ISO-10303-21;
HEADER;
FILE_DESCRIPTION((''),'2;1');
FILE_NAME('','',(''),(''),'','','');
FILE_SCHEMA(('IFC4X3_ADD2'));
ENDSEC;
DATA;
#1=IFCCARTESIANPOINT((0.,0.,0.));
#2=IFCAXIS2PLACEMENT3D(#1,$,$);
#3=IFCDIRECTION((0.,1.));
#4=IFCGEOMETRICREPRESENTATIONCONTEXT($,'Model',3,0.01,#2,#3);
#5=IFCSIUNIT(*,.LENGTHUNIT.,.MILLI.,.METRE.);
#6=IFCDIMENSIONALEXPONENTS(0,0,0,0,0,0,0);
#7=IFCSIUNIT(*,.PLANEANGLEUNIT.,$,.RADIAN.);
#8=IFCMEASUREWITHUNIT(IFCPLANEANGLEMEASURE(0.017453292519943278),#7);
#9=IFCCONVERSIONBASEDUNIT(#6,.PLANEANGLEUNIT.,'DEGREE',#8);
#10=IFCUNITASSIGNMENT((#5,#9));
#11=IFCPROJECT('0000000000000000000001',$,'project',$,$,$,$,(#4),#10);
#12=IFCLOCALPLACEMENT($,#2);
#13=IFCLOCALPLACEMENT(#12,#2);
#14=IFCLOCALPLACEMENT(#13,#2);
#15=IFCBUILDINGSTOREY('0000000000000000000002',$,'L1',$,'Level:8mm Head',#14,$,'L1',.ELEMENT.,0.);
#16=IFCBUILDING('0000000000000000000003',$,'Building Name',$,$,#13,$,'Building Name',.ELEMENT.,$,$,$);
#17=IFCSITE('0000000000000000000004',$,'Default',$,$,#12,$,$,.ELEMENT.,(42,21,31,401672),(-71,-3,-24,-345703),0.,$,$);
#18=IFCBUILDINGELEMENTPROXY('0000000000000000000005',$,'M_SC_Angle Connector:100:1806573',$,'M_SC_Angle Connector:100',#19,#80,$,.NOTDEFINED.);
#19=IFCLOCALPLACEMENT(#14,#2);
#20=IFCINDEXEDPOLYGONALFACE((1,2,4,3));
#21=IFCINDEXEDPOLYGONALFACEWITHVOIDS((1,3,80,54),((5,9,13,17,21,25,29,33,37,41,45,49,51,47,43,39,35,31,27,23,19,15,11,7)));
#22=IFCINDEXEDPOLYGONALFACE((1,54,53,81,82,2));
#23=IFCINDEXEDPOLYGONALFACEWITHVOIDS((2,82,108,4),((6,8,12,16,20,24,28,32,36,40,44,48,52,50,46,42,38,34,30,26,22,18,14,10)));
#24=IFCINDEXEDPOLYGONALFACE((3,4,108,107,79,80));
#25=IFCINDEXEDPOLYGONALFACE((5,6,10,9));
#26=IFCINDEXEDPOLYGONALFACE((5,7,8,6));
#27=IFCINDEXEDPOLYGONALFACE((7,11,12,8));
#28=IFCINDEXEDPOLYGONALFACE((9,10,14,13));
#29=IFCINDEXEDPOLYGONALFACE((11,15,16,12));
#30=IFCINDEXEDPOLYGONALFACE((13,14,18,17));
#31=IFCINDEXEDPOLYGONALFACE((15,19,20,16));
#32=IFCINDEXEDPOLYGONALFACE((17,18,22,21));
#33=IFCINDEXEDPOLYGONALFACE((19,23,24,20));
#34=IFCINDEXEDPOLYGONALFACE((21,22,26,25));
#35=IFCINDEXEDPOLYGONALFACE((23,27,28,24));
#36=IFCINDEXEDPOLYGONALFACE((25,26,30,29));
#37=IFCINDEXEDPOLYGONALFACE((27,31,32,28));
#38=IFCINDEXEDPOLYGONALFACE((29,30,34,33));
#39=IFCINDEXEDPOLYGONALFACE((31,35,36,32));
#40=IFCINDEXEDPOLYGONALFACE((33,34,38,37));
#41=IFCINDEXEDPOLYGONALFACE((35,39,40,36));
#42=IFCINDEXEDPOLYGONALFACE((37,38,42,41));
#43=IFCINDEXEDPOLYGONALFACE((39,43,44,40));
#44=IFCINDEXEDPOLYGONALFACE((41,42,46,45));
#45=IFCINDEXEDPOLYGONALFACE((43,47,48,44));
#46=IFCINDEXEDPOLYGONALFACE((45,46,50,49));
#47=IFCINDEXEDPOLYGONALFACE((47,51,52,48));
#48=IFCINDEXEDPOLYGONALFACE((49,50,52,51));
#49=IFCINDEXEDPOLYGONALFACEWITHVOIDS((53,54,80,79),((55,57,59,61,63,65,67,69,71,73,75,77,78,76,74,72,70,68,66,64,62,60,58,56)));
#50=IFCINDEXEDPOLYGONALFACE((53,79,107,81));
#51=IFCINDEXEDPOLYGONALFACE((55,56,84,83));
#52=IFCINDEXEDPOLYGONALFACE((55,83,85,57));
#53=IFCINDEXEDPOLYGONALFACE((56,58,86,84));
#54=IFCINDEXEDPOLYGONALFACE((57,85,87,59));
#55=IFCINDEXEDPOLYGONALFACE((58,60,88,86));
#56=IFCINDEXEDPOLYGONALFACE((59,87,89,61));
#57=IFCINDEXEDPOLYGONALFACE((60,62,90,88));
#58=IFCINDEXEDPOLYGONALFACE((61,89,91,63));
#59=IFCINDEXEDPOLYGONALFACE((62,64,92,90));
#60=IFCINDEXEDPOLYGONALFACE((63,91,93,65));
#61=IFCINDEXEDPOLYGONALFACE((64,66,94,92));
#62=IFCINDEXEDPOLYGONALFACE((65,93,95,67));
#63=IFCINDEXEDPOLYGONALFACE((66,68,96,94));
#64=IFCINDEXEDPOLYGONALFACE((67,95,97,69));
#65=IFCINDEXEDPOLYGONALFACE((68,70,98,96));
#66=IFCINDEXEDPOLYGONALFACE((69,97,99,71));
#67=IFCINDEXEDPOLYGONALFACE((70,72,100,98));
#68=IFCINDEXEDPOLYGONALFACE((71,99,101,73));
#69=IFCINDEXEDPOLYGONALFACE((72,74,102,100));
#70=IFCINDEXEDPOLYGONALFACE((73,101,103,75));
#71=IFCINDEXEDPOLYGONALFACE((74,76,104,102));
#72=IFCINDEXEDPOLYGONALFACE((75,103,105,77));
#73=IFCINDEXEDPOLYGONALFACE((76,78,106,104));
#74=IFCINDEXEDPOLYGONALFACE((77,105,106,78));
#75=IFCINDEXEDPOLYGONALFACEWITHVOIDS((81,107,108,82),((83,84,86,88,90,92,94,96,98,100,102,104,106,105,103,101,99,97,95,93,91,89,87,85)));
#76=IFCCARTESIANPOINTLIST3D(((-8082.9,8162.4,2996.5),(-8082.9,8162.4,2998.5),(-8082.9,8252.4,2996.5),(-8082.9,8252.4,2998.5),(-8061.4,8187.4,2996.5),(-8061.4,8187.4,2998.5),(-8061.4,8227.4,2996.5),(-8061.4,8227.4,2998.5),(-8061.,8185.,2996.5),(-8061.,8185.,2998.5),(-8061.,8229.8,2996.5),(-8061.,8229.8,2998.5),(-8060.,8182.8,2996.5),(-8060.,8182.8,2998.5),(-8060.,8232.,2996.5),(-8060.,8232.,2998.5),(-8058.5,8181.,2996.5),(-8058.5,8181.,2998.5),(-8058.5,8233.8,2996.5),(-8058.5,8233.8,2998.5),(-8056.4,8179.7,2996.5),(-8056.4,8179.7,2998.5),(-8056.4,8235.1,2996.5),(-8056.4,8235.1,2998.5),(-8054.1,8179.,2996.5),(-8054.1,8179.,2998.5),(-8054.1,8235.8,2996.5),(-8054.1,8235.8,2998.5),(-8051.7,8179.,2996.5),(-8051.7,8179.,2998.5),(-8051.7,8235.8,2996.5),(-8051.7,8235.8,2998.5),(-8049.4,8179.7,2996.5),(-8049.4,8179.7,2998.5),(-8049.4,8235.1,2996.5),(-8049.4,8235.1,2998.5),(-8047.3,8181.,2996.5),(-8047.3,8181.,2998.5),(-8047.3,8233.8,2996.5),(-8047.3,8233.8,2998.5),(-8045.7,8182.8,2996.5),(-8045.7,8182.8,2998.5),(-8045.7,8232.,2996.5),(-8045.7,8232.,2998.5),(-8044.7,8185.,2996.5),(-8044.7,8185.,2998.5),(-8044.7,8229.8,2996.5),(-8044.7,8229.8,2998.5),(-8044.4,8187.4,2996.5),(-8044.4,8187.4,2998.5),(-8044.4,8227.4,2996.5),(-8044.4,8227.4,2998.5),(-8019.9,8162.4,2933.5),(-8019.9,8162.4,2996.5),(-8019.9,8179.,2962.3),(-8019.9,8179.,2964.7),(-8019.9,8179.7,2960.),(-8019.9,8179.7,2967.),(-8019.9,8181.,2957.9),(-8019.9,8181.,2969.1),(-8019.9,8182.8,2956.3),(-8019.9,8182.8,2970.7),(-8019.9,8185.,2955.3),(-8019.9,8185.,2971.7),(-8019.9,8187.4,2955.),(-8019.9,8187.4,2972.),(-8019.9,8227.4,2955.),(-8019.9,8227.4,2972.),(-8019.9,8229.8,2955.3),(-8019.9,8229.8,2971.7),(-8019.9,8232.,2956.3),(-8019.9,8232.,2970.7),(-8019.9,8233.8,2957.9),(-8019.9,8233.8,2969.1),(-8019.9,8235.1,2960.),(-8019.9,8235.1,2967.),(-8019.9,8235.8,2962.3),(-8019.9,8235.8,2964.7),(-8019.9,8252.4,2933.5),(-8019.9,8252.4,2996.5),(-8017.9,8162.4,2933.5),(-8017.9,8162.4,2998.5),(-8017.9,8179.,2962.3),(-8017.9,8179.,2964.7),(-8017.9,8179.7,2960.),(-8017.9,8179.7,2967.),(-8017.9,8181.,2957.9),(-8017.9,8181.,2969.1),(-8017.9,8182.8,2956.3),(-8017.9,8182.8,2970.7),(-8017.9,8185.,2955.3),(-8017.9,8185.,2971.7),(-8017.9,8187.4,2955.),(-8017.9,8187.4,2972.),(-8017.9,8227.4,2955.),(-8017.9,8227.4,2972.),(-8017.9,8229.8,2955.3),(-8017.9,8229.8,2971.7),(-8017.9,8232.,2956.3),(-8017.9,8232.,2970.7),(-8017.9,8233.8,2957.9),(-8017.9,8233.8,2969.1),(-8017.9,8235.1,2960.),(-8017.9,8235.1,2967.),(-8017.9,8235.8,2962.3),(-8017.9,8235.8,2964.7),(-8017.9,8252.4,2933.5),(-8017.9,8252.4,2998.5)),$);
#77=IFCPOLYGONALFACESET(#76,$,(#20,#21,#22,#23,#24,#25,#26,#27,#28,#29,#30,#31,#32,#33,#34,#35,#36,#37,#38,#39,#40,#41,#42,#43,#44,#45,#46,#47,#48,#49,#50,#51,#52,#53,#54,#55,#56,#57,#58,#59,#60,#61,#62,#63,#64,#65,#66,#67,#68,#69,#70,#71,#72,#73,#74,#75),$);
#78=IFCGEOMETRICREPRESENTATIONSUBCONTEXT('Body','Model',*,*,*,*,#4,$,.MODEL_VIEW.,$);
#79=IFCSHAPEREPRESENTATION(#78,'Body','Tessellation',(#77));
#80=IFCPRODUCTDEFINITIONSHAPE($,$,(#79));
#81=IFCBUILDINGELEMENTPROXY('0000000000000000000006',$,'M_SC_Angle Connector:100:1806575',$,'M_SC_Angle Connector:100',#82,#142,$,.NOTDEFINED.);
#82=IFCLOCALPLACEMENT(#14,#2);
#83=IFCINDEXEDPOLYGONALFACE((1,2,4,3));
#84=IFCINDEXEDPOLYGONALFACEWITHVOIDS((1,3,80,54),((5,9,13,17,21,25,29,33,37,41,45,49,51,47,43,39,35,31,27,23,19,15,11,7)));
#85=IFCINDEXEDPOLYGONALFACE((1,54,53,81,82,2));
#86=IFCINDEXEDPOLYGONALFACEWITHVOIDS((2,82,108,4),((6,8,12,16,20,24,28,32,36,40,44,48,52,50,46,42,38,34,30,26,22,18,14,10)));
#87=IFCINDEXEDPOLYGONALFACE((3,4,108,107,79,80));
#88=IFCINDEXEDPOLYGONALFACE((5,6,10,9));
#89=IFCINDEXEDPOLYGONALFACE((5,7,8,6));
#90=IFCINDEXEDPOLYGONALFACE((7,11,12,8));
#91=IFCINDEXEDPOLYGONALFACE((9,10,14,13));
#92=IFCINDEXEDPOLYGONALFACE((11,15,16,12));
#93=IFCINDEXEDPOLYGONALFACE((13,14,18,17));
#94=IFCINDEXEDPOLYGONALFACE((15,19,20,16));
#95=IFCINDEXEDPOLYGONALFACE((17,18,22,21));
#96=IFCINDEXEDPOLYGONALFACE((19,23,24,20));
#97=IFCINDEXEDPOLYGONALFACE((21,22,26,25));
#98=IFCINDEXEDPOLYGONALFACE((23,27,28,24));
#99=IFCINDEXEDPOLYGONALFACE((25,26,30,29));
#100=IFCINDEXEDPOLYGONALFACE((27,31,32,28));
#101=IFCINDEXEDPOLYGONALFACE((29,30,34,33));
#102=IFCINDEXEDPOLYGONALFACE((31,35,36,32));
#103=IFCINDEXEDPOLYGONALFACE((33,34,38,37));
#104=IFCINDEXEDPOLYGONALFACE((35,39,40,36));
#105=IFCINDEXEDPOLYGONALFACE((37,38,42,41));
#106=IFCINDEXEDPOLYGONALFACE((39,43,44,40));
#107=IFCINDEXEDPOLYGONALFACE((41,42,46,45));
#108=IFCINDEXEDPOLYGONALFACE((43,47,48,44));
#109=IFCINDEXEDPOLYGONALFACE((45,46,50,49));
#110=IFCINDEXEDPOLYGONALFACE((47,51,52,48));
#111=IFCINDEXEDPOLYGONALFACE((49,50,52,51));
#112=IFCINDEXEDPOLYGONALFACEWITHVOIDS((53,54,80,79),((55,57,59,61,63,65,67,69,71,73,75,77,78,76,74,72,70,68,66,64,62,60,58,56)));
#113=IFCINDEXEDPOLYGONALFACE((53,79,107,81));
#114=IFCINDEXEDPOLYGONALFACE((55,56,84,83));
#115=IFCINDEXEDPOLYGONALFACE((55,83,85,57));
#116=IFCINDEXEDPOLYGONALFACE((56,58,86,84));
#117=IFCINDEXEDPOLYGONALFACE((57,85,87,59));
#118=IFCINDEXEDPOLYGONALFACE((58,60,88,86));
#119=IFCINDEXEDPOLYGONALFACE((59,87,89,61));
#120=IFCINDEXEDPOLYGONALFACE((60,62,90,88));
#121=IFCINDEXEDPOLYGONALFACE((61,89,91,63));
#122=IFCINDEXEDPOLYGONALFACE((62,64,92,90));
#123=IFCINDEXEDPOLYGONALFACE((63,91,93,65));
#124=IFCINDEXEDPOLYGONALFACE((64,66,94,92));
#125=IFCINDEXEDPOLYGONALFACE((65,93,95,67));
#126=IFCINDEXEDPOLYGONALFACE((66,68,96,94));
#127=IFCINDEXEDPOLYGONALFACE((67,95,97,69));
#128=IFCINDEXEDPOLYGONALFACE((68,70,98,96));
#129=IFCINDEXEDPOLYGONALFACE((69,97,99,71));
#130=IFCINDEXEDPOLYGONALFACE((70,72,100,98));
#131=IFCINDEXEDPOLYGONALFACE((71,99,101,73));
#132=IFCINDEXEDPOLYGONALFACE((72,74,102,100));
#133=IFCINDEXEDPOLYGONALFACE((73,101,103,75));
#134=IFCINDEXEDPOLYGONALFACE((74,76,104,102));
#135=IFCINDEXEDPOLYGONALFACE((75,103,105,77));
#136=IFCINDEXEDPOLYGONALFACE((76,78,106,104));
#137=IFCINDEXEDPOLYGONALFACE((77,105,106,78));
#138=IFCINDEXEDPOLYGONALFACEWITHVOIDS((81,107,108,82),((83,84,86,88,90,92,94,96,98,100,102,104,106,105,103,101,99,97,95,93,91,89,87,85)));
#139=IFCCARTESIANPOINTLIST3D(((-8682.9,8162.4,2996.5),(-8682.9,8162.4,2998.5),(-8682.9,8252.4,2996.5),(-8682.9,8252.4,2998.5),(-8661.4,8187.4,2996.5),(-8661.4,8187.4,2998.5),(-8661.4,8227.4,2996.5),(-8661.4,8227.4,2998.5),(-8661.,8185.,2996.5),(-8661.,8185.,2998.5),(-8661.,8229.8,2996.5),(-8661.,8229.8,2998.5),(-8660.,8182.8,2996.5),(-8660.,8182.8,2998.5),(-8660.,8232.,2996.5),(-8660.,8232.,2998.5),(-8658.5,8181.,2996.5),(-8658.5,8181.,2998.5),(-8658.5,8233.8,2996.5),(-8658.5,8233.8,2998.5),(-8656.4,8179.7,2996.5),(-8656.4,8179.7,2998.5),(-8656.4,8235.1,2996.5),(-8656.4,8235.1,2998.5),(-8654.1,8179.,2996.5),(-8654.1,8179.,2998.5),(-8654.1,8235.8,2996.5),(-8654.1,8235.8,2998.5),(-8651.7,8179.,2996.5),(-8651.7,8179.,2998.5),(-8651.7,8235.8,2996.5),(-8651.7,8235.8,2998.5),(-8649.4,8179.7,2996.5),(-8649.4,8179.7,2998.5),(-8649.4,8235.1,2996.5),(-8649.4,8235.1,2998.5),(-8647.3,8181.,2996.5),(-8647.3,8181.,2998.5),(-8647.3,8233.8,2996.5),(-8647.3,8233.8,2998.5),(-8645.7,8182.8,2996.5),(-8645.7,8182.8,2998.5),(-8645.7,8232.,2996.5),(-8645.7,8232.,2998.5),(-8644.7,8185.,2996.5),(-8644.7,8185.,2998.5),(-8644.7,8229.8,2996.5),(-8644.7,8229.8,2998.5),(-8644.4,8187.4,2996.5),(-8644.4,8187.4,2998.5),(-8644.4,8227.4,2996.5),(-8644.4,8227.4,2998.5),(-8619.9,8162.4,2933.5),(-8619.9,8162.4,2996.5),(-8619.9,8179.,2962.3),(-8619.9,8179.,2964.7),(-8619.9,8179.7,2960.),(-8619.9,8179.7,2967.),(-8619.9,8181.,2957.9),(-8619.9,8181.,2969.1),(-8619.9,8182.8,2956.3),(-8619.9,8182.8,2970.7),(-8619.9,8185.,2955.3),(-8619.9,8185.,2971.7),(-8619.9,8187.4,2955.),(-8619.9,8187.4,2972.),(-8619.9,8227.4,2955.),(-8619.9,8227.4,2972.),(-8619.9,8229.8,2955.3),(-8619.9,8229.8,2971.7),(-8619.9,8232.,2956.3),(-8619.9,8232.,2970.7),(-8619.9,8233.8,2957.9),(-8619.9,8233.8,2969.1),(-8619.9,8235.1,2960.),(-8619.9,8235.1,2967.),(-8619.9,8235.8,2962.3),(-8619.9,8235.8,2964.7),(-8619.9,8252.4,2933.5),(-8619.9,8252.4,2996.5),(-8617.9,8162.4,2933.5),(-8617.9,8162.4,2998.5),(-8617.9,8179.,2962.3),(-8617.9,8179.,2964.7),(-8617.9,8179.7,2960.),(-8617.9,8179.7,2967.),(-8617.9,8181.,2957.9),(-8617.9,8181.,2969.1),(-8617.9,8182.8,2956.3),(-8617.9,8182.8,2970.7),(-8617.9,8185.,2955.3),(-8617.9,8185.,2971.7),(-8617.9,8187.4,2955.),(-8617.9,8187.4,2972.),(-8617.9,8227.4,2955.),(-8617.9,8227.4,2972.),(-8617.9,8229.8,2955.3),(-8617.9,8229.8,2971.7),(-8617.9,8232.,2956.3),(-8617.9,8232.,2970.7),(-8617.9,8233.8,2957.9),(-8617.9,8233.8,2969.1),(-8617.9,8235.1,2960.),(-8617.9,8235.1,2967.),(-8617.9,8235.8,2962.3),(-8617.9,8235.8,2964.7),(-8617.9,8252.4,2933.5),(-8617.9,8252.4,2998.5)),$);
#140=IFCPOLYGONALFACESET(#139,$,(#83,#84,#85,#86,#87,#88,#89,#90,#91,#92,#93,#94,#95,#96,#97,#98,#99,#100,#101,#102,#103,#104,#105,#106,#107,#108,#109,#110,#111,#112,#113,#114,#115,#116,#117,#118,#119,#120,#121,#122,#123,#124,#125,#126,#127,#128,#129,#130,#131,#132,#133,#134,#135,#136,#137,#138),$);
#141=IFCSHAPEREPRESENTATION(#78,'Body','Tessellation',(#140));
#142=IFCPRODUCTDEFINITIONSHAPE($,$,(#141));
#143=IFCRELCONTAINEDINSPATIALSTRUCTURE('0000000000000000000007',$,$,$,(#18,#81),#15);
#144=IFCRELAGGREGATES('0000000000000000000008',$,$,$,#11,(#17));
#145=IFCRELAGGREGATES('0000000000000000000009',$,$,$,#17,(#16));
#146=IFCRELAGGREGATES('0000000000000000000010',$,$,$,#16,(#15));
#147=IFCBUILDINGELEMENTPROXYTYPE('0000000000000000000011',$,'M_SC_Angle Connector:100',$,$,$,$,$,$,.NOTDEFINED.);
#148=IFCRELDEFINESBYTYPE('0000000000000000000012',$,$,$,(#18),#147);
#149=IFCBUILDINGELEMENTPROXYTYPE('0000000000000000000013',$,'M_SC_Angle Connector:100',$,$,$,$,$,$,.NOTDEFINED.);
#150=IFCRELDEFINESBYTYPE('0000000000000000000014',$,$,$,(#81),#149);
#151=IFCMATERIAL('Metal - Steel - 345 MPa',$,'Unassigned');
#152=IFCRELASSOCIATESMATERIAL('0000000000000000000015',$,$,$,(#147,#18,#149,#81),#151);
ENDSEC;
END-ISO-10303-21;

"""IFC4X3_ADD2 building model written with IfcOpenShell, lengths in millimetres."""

from ifc_helpers import new_model, entity, si_unit, converted_unit, direction, frame, frame_2d, origin, place, context, subcontext, project, spatial, polyline, circle_curve, parameter, trimmed, segment, composite_curve, outline, extrude, source, transform, mapped, material, type_object, type_shapes, element, save


model = new_model("IFC4X3_ADD2")

# Units and contexts
model_context = context("Model", 3, precision=0.01, world=origin(), true_north=direction((0.0, 1.0)))
body_context = subcontext(model_context, "Body", "Model", "MODEL_VIEW")
ifc_project = project(units=[si_unit("LENGTHUNIT", "METRE", prefix="MILLI"), converted_unit("PLANEANGLEUNIT", "DEGREE", entity("IfcPlaneAngleMeasure", 0.017453292519943278), si_unit("PLANEANGLEUNIT", "RADIAN"), dimensions=[0, 0, 0, 0, 0, 0, 0])], contexts=[model_context])

# Site, building, storey
site_placement = place(None, origin())
site = spatial("IfcSite", under=ifc_project, at=site_placement, Name="Default", CompositionType="ELEMENT", RefLatitude=(42, 21, 31, 401672), RefLongitude=(-71, -3, -24, -345703), RefElevation=0.0)
building_placement = place(site_placement, origin())
building = spatial("IfcBuilding", under=site, at=building_placement, Name="Building Name", LongName="Building Name", CompositionType="ELEMENT")
storey_placement = place(building_placement, origin())
storey = spatial("IfcBuildingStorey", under=building, at=storey_placement, Name="L1", ObjectType="Level:8mm Head", LongName="L1", CompositionType="ELEMENT", Elevation=0.0)

# Building element proxies, openings
ifc_material_1 = material(Name="Metal - Steel - 345 MPa", Category="Unassigned")
building_element_proxy_type_1 = type_object("IfcBuildingElementProxyType", Name="M_SC_Angle Connector:100", PredefinedType="NOTDEFINED", material=ifc_material_1)
shared_shape_1 = source(origin(), body_context, "Body", "SweptSolid", [
    extrude(outline(polyline([(-42.7, -22.3), (22.3, -22.3), (22.3, 42.7), (20.3, 42.7), (20.3, -20.3), (-42.7, -20.3), (-42.7, -22.3)])), frame((22.3, -45.0, 22.3), z_axis=(0.0, 1.0, 0.0), x_axis=(-1.0, 0.0, 0.0)), (0.0, 0.0, 1.0), 90.0),
])
type_shapes(building_element_proxy_type_1, [shared_shape_1])
proxy_1_placement = place(storey_placement, frame((-8017.9, 8207.4, 2998.5), z_axis=(0.0, 0.0, -1.0), x_axis=(-1.0, 0.0, 0.0)))
proxy_1 = element("IfcBuildingElementProxy", 1, at=proxy_1_placement, inside=storey, type_object=building_element_proxy_type_1, material=ifc_material_1, Name="M_SC_Angle Connector:100:1806573", ObjectType="M_SC_Angle Connector:100", PredefinedType="NOTDEFINED", context=body_context, shape_type="MappedRepresentation", body=[
    mapped(shared_shape_1, transform((0.0, 0.0, 0.0), scale=1.0)),
])
opening_1_placement = place(storey_placement, frame((-8017.9, 8207.4, 2998.5)))
element("IfcOpeningElement", 2, at=opening_1_placement, cuts=proxy_1, PredefinedType="OPENING", context=body_context, shape_type="SweptSolid", body=[
    extrude(outline(composite_curve([segment(trimmed(circle_curve(frame_2d((0.0, -20.0), x_axis=(1.0, 0.0)), 8.5), [parameter(180.0)], [parameter(0.0)], True, "PARAMETER"), True, "CONTINUOUS"), segment(polyline([(8.5, -20.0), (8.5, 20.0)]), True, "CONTINUOUS"), segment(trimmed(circle_curve(frame_2d((0.0, 20.0), x_axis=(1.0, 0.0)), 8.5), [parameter(0.0)], [parameter(180.0)], True, "PARAMETER"), True, "CONTINUOUS"), segment(polyline([(-8.5, 20.0), (-8.5, -20.0)]), True, "CONTINUOUS")], self_intersect=False)), frame((-2.0, 0.0, -35.0), z_axis=(1.0, 0.0, 0.0), x_axis=(0.0, 0.0, -1.0)), (0.0, 0.0, 1.0), 2.0),
])
opening_2_placement = place(storey_placement, frame((-8017.9, 8207.4, 2998.5)))
element("IfcOpeningElement", 3, at=opening_2_placement, cuts=proxy_1, PredefinedType="OPENING", context=body_context, shape_type="SweptSolid", body=[
    extrude(outline(composite_curve([segment(trimmed(circle_curve(frame_2d((0.0, 20.0), x_axis=(1.0, 0.0)), 8.5), [parameter(0.0)], [parameter(180.0)], True, "PARAMETER"), True, "CONTINUOUS"), segment(polyline([(-8.5, 20.0), (-8.5, -20.0)]), True, "CONTINUOUS"), segment(trimmed(circle_curve(frame_2d((0.0, -20.0), x_axis=(1.0, 0.0)), 8.5), [parameter(180.0)], [parameter(0.0)], True, "PARAMETER"), True, "CONTINUOUS"), segment(polyline([(8.5, -20.0), (8.5, 20.0)]), True, "CONTINUOUS")], self_intersect=False)), frame((-35.0, 0.0, -2.0), z_axis=(0.0, 0.0, 1.0), x_axis=(-1.0, 0.0, 0.0)), (0.0, 0.0, 1.0), 2.0),
])
building_element_proxy_type_2 = type_object("IfcBuildingElementProxyType", Name="M_SC_Angle Connector:100", PredefinedType="NOTDEFINED", material=ifc_material_1)
shared_shape_2 = source(origin(), body_context, "Body", "SweptSolid", [
    extrude(outline(polyline([(-42.7, -22.3), (22.3, -22.3), (22.3, 42.7), (20.3, 42.7), (20.3, -20.3), (-42.7, -20.3), (-42.7, -22.3)])), frame((22.3, -45.0, 22.3), z_axis=(0.0, 1.0, 0.0), x_axis=(-1.0, 0.0, 0.0)), (0.0, 0.0, 1.0), 90.0),
])
type_shapes(building_element_proxy_type_2, [shared_shape_2])
proxy_2_placement = place(storey_placement, frame((-8617.9, 8207.4, 2998.5), z_axis=(0.0, 0.0, -1.0), x_axis=(-1.0, 0.0, 0.0)))
proxy_2 = element("IfcBuildingElementProxy", 4, at=proxy_2_placement, inside=storey, type_object=building_element_proxy_type_2, material=ifc_material_1, Name="M_SC_Angle Connector:100:1806575", ObjectType="M_SC_Angle Connector:100", PredefinedType="NOTDEFINED", context=body_context, shape_type="MappedRepresentation", body=[
    mapped(shared_shape_2, transform((0.0, 0.0, 0.0), scale=1.0)),
])
opening_3_placement = place(storey_placement, frame((-8617.9, 8207.4, 2998.5)))
element("IfcOpeningElement", 5, at=opening_3_placement, cuts=proxy_2, PredefinedType="OPENING", context=body_context, shape_type="SweptSolid", body=[
    extrude(outline(composite_curve([segment(trimmed(circle_curve(frame_2d((0.0, -20.0), x_axis=(1.0, 0.0)), 8.5), [parameter(180.0)], [parameter(0.0)], True, "PARAMETER"), True, "CONTINUOUS"), segment(polyline([(8.5, -20.0), (8.5, 20.0)]), True, "CONTINUOUS"), segment(trimmed(circle_curve(frame_2d((0.0, 20.0), x_axis=(1.0, 0.0)), 8.5), [parameter(0.0)], [parameter(180.0)], True, "PARAMETER"), True, "CONTINUOUS"), segment(polyline([(-8.5, 20.0), (-8.5, -20.0)]), True, "CONTINUOUS")], self_intersect=False)), frame((-2.0, 0.0, -35.0), z_axis=(1.0, 0.0, 0.0), x_axis=(0.0, 0.0, -1.0)), (0.0, 0.0, 1.0), 2.0),
])
opening_4_placement = place(storey_placement, frame((-8617.9, 8207.4, 2998.5)))
element("IfcOpeningElement", 6, at=opening_4_placement, cuts=proxy_2, PredefinedType="OPENING", context=body_context, shape_type="SweptSolid", body=[
    extrude(outline(composite_curve([segment(trimmed(circle_curve(frame_2d((0.0, 20.0), x_axis=(1.0, 0.0)), 8.5), [parameter(0.0)], [parameter(180.0)], True, "PARAMETER"), True, "CONTINUOUS"), segment(polyline([(-8.5, 20.0), (-8.5, -20.0)]), True, "CONTINUOUS"), segment(trimmed(circle_curve(frame_2d((0.0, -20.0), x_axis=(1.0, 0.0)), 8.5), [parameter(180.0)], [parameter(0.0)], True, "PARAMETER"), True, "CONTINUOUS"), segment(polyline([(8.5, -20.0), (8.5, 20.0)]), True, "CONTINUOUS")], self_intersect=False)), frame((-35.0, 0.0, -2.0), z_axis=(0.0, 0.0, 1.0), x_axis=(-1.0, 0.0, 0.0)), (0.0, 0.0, 1.0), 2.0),
])

save(model, "model.ifc")
